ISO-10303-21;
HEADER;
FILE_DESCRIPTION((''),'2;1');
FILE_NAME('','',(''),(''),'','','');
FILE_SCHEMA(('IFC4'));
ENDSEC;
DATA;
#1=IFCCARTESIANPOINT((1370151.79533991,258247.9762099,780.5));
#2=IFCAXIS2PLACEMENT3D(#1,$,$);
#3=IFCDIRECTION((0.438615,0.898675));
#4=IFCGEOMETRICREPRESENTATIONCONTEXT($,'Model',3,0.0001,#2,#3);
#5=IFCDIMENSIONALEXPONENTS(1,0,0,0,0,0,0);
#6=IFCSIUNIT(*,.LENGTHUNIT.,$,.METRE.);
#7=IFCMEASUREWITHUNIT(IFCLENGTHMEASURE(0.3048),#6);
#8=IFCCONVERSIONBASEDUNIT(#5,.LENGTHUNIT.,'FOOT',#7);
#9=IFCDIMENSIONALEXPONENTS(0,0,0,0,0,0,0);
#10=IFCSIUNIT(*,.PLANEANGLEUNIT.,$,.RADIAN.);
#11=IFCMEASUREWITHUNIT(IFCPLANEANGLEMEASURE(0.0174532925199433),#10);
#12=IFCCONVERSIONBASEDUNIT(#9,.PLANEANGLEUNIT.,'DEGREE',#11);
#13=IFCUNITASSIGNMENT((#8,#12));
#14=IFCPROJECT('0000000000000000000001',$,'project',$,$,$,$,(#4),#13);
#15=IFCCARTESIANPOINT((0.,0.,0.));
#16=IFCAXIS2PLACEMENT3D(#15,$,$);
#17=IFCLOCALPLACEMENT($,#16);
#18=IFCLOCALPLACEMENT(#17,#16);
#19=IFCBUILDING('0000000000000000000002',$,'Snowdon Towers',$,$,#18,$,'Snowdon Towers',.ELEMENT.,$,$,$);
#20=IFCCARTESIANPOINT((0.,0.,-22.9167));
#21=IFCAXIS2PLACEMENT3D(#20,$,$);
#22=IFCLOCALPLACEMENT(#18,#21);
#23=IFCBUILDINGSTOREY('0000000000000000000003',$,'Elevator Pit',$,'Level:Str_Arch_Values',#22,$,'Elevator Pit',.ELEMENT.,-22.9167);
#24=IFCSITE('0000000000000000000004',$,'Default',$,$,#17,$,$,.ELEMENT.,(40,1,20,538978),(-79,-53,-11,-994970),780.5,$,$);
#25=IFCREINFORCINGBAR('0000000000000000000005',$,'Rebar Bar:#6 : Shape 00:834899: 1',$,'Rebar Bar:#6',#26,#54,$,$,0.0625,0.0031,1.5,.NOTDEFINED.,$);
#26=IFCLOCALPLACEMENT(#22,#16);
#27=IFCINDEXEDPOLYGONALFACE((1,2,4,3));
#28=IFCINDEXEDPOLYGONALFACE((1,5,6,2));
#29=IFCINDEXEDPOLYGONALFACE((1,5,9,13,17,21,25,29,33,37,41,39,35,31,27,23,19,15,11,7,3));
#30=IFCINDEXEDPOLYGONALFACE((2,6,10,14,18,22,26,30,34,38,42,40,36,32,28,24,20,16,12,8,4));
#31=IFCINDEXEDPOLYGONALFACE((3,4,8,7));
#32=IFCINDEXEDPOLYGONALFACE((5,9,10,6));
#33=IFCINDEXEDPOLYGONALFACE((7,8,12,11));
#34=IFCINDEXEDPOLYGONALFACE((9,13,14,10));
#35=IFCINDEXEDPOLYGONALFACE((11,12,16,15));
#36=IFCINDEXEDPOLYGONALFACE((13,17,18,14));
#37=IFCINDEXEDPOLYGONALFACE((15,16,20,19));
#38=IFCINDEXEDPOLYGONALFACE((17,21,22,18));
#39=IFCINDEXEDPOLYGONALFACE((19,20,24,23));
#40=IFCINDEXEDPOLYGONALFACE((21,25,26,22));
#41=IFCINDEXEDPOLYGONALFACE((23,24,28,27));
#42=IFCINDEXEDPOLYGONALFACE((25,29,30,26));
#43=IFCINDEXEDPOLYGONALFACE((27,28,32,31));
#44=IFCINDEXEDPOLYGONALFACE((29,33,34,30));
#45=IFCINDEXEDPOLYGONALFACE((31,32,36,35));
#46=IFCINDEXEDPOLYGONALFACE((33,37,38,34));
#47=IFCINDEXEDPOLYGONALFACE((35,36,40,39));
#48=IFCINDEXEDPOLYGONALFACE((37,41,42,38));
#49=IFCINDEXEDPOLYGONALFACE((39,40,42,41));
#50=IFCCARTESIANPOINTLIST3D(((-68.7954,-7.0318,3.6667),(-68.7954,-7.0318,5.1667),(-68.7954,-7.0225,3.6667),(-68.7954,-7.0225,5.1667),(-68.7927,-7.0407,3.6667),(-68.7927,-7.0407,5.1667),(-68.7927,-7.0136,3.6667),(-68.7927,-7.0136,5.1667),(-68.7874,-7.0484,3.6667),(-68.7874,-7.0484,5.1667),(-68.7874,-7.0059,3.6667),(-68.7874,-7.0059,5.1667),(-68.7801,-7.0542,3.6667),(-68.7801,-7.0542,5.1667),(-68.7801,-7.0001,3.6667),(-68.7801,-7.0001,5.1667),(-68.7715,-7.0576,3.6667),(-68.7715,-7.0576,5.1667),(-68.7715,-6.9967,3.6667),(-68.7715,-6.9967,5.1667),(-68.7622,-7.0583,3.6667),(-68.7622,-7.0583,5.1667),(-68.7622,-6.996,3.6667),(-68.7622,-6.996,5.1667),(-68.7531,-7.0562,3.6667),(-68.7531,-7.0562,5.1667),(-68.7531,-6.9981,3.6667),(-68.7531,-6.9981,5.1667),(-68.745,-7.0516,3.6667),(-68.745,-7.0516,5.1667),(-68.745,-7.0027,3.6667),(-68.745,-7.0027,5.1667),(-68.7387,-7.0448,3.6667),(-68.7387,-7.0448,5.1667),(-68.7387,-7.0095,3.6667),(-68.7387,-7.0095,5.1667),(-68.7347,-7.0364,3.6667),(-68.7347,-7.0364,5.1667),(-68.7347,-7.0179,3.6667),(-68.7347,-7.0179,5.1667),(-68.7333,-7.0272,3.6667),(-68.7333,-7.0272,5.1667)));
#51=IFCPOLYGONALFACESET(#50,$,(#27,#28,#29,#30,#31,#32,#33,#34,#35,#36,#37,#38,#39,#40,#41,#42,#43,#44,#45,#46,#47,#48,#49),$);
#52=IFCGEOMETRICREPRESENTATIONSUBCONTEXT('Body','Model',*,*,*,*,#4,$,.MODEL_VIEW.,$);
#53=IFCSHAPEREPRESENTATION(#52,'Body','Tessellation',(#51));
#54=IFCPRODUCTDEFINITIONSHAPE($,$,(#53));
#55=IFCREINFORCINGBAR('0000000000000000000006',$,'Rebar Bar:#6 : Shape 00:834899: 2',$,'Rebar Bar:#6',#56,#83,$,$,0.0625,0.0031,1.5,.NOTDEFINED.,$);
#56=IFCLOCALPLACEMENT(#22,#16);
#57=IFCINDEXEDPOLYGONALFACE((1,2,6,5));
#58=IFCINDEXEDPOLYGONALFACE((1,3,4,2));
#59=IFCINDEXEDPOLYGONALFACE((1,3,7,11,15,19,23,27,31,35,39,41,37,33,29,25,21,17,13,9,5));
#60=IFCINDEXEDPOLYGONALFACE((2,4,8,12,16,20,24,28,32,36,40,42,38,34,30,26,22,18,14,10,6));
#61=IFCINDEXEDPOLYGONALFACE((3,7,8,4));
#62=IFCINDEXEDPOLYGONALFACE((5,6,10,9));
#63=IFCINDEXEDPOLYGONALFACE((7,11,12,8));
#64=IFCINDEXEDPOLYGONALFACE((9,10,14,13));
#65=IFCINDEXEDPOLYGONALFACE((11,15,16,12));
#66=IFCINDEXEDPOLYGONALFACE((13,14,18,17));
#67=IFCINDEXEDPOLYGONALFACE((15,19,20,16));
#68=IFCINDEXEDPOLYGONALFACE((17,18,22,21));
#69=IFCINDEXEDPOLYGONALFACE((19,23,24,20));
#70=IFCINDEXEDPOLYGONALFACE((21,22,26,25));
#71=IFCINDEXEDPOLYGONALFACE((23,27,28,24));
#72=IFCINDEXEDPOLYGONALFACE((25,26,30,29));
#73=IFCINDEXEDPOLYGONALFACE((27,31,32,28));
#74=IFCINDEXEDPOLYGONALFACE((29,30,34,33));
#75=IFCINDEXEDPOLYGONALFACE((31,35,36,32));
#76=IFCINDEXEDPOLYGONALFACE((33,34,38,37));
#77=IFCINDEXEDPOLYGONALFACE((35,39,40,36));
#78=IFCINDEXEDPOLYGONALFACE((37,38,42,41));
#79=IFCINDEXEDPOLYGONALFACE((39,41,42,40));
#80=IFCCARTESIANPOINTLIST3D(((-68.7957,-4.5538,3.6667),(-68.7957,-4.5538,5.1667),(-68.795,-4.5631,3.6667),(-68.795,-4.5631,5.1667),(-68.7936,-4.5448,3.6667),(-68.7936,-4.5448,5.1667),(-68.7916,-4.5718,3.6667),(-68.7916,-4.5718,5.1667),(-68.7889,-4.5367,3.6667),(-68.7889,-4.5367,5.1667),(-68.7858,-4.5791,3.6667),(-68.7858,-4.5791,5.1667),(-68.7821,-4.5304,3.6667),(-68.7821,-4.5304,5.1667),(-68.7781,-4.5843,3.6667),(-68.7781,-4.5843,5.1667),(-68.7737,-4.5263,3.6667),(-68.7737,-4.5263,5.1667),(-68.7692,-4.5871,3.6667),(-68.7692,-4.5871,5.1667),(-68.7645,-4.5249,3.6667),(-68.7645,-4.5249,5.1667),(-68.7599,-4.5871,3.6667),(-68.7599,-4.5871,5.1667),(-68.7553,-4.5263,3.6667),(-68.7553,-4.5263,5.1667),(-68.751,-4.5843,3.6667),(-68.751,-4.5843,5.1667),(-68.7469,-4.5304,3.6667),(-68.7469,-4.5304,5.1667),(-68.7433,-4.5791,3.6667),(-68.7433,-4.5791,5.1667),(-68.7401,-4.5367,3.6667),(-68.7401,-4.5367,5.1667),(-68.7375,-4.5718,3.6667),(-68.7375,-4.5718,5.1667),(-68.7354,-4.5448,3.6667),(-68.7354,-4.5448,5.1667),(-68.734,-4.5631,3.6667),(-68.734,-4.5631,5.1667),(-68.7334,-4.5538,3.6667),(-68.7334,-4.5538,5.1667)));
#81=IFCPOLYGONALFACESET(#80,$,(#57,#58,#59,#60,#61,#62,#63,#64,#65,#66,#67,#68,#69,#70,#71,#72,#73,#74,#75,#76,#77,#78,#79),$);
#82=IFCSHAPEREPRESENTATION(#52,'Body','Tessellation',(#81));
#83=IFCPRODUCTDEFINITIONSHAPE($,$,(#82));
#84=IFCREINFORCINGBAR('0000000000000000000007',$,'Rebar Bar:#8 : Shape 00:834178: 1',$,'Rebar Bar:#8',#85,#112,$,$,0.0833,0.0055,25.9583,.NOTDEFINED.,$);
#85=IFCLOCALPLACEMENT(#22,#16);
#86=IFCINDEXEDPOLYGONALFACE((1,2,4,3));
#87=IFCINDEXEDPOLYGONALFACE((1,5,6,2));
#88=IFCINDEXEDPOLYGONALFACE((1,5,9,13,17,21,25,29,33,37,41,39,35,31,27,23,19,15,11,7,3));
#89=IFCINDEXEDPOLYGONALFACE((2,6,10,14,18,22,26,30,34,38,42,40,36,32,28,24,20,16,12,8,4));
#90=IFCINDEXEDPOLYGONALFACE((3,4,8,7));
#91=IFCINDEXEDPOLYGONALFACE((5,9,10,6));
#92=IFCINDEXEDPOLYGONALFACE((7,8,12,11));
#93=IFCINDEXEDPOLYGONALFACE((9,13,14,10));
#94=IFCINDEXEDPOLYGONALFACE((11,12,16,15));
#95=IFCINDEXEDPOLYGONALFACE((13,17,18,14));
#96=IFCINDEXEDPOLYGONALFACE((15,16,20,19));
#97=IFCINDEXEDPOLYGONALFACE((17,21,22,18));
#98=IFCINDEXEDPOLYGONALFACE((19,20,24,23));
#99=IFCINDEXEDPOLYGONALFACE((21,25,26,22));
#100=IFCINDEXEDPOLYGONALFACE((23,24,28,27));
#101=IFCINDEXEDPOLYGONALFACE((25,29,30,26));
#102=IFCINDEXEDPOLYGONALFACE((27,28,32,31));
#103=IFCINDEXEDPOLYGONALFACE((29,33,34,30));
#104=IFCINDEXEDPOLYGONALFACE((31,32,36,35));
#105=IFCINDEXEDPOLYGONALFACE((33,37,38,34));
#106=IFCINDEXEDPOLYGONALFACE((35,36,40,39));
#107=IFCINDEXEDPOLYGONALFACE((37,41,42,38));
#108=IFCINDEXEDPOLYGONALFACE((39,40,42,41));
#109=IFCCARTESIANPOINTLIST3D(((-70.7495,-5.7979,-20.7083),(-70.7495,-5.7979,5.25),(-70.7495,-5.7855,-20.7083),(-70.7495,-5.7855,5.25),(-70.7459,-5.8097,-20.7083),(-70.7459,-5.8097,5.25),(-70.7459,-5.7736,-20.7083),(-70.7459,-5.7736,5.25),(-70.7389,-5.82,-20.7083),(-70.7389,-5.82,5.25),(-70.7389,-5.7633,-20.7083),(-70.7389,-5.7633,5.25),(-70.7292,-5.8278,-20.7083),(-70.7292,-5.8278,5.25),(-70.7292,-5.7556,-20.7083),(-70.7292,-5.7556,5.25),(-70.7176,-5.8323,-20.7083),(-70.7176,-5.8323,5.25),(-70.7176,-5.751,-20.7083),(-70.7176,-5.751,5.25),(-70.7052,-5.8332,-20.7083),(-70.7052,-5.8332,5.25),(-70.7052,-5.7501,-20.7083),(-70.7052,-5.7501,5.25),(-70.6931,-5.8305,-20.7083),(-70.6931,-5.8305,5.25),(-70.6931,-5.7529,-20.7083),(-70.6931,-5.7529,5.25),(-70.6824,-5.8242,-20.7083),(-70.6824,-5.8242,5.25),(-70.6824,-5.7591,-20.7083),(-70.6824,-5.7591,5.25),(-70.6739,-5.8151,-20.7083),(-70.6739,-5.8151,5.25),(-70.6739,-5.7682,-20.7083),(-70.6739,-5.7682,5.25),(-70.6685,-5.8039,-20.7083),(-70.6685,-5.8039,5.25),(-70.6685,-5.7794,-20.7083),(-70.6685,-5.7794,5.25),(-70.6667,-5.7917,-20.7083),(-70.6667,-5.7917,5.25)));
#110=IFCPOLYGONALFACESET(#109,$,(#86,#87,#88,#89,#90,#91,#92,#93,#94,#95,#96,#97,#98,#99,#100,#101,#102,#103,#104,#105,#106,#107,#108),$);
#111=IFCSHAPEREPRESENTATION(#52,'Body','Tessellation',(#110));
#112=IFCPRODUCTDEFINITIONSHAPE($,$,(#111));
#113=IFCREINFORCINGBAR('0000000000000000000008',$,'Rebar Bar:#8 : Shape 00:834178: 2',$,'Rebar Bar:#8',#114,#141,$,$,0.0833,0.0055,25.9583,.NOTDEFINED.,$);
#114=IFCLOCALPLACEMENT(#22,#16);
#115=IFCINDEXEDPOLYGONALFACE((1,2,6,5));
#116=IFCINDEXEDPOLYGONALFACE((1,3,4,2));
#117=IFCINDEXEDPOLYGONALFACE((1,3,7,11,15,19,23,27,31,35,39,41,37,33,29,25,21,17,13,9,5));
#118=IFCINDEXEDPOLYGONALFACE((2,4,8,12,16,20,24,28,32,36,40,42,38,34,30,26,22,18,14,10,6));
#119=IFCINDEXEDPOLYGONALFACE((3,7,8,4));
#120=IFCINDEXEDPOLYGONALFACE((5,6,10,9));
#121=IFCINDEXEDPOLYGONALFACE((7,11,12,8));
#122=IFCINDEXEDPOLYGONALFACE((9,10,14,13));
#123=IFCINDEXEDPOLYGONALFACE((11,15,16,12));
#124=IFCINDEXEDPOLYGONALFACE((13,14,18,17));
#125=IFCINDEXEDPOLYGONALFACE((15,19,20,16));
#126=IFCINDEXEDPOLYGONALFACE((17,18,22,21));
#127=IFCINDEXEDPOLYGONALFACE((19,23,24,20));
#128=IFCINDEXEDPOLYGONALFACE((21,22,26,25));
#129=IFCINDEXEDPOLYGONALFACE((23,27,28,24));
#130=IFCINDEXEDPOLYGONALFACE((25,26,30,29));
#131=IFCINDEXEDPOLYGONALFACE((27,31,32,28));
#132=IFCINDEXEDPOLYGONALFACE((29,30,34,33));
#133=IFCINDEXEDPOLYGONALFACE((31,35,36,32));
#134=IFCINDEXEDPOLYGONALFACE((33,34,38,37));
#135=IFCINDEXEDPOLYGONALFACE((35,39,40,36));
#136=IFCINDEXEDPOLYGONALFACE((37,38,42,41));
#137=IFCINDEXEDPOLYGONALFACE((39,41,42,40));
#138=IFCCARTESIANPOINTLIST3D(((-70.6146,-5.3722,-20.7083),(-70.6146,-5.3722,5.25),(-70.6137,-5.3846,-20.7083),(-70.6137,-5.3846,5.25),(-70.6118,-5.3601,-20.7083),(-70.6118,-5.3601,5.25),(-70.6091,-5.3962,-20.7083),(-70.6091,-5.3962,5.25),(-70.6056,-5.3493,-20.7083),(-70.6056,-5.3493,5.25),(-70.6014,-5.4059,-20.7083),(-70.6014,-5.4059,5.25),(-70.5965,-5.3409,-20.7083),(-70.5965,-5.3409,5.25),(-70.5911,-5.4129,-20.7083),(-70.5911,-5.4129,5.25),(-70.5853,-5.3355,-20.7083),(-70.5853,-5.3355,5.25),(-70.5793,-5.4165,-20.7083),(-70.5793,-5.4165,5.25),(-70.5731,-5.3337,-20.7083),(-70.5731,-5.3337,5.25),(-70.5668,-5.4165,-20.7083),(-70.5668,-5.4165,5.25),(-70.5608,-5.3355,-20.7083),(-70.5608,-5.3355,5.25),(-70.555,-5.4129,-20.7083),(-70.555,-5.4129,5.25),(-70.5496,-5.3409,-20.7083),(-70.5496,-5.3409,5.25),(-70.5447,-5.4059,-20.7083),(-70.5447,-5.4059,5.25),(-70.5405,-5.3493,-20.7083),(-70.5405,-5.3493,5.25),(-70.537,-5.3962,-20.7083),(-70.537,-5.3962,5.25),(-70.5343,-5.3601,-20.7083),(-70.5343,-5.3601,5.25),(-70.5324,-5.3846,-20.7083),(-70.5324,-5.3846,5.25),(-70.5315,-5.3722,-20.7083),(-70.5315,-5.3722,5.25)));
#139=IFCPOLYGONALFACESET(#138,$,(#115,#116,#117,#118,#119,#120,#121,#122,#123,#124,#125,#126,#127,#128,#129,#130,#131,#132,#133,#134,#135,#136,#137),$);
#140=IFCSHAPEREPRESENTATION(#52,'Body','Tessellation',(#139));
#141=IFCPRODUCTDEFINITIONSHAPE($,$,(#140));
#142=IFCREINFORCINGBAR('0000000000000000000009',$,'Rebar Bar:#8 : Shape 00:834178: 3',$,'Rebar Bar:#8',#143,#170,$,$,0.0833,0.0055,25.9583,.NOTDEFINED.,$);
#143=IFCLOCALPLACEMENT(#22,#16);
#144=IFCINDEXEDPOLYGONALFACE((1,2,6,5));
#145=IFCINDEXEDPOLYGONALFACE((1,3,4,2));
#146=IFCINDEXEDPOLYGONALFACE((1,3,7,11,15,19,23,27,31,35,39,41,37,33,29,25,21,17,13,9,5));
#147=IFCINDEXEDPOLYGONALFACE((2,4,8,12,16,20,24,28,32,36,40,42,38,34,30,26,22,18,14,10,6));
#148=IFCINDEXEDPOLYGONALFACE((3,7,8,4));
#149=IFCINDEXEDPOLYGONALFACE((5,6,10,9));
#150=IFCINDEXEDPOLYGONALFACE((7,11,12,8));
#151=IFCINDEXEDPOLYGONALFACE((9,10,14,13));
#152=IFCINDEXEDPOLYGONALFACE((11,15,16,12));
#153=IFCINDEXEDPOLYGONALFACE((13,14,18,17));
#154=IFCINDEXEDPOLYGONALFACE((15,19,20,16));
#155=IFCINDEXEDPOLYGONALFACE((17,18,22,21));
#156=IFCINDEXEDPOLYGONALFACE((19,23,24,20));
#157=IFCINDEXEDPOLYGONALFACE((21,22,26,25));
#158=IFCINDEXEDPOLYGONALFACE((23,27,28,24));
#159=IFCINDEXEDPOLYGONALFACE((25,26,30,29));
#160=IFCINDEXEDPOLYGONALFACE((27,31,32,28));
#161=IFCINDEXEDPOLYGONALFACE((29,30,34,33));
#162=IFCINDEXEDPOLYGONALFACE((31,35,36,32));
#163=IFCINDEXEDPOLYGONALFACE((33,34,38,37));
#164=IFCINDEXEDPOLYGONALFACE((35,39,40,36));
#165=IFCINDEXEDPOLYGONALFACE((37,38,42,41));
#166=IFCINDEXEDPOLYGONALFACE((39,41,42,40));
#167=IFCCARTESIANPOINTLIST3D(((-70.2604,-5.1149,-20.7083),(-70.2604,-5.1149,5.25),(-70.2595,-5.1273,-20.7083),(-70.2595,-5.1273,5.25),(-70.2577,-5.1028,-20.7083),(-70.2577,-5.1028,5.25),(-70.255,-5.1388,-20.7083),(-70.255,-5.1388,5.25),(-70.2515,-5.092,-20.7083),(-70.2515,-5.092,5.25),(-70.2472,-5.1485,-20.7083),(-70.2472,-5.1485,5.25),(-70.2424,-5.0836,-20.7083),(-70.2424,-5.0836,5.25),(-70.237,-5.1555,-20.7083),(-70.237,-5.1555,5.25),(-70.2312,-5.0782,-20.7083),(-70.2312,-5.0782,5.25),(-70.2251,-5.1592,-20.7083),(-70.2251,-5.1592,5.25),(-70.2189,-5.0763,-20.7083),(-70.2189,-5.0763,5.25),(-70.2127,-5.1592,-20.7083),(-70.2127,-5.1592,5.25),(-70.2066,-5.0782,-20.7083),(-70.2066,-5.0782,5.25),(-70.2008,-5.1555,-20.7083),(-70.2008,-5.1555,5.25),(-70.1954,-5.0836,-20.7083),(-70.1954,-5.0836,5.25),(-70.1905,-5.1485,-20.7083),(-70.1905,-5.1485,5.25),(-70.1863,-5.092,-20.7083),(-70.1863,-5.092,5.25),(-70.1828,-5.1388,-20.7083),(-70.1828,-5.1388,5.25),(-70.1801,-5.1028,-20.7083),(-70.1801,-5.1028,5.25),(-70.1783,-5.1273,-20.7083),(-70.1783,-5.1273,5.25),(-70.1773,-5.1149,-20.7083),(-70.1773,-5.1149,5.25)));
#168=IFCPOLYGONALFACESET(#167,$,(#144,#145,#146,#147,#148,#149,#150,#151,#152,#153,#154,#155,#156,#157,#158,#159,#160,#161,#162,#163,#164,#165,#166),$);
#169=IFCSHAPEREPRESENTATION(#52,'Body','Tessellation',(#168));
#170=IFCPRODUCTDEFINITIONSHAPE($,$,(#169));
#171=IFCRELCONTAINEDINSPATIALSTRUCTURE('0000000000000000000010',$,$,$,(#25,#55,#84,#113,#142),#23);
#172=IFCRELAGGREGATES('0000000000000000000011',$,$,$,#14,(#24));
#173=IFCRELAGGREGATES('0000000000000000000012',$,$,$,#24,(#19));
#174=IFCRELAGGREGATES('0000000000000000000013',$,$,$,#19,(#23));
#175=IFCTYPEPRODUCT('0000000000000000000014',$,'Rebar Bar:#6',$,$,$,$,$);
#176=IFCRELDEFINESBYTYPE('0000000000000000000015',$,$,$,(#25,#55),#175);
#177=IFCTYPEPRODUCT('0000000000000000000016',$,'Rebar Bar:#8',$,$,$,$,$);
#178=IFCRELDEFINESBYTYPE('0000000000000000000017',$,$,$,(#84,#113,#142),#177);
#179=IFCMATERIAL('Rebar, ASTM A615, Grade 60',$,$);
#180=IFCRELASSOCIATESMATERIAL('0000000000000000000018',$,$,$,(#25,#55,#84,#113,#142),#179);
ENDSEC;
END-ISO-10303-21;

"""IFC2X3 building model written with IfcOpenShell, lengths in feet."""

from ifc_helpers import new_model, entity, si_unit, converted_unit, direction, frame, origin, place, context, subcontext, project, spatial, material, type_object, element, save


model = new_model("IFC2X3")

# Units and contexts
model_context = context("Model", 3, precision=0.0001, world=frame((1370151.79533991, 258247.9762099, 780.5)), true_north=direction((0.438615, 0.898675)))
body_context = subcontext(model_context, "Body", "Model", "MODEL_VIEW")
ifc_project = project(units=[converted_unit("LENGTHUNIT", "FOOT", entity("IfcLengthMeasure", 0.3048), si_unit("LENGTHUNIT", "METRE"), dimensions=[1, 0, 0, 0, 0, 0, 0]), converted_unit("PLANEANGLEUNIT", "DEGREE", entity("IfcPlaneAngleMeasure", 0.0174532925199433), si_unit("PLANEANGLEUNIT", "RADIAN"), dimensions=[0, 0, 0, 0, 0, 0, 0])], contexts=[model_context])

# Site, building, storey
site_placement = place(None, origin())
site = spatial("IfcSite", under=ifc_project, at=site_placement, Name="Default", CompositionType="ELEMENT", RefLatitude=(40, 1, 20, 538978), RefLongitude=(-79, -53, -11, -994970), RefElevation=780.5)
building_placement = place(site_placement, origin())
building = spatial("IfcBuilding", under=site, at=building_placement, Name="Snowdon Towers", LongName="Snowdon Towers", CompositionType="ELEMENT")
storey_placement = place(building_placement, frame((0.0, 0.0, -22.9167)))
storey = spatial("IfcBuildingStorey", under=building, at=storey_placement, Name="Elevator Pit", ObjectType="Level:Str_Arch_Values", LongName="Elevator Pit", CompositionType="ELEMENT", Elevation=-22.9167)

# Reinforcing bars
ifc_material = material(Name="Rebar, ASTM A615, Grade 60")
type_product_1 = type_object("IfcTypeProduct", Name="Rebar Bar:#6")
reinforcing_bar_1_placement = place(storey_placement, origin())
element("IfcReinforcingBar", 1, at=reinforcing_bar_1_placement, inside=storey, type_object=type_product_1, material=ifc_material, Name="Rebar Bar:#6 : Shape 00:834899: 1", ObjectType="Rebar Bar:#6", BarLength=1.5, BarRole="NOTDEFINED", CrossSectionArea=0.0031, NominalDiameter=0.0625, context=body_context, shape_type="AdvancedSweptSolid", body=[
    entity("IfcSweptDiskSolid", entity("IfcCompositeCurve", [entity("IfcCompositeCurveSegment", "CONTINUOUS", True, entity("IfcPolyline", [entity("IfcCartesianPoint", [-68.7645, -7.0272, 3.6667]), entity("IfcCartesianPoint", [-68.7645, -7.0272, 5.1667])]))], False), 0.0312, None, 0.0, 1.0),
])
reinforcing_bar_2_placement = place(storey_placement, origin())
element("IfcReinforcingBar", 2, at=reinforcing_bar_2_placement, inside=storey, type_object=type_product_1, material=ifc_material, Name="Rebar Bar:#6 : Shape 00:834899: 2", ObjectType="Rebar Bar:#6", BarLength=1.5, BarRole="NOTDEFINED", CrossSectionArea=0.0031, NominalDiameter=0.0625, context=body_context, shape_type="AdvancedSweptSolid", body=[
    entity("IfcSweptDiskSolid", entity("IfcCompositeCurve", [entity("IfcCompositeCurveSegment", "CONTINUOUS", True, entity("IfcPolyline", [entity("IfcCartesianPoint", [-68.7645, -4.5562, 3.6667]), entity("IfcCartesianPoint", [-68.7645, -4.5562, 5.1667])]))], False), 0.0312, None, 0.0, 1.0),
])
type_product_2 = type_object("IfcTypeProduct", Name="Rebar Bar:#8")
reinforcing_bar_3_placement = place(storey_placement, origin())
element("IfcReinforcingBar", 3, at=reinforcing_bar_3_placement, inside=storey, type_object=type_product_2, material=ifc_material, Name="Rebar Bar:#8 : Shape 00:834178: 1", ObjectType="Rebar Bar:#8", BarLength=25.9583, BarRole="NOTDEFINED", CrossSectionArea=0.0055, NominalDiameter=0.0833, context=body_context, shape_type="AdvancedSweptSolid", body=[
    entity("IfcSweptDiskSolid", entity("IfcCompositeCurve", [entity("IfcCompositeCurveSegment", "CONTINUOUS", True, entity("IfcPolyline", [entity("IfcCartesianPoint", [-70.7083, -5.7917, -20.7083]), entity("IfcCartesianPoint", [-70.7083, -5.7917, 5.25])]))], False), 0.0417, None, 0.0, 1.0),
])
reinforcing_bar_4_placement = place(storey_placement, origin())
element("IfcReinforcingBar", 4, at=reinforcing_bar_4_placement, inside=storey, type_object=type_product_2, material=ifc_material, Name="Rebar Bar:#8 : Shape 00:834178: 2", ObjectType="Rebar Bar:#8", BarLength=25.9583, BarRole="NOTDEFINED", CrossSectionArea=0.0055, NominalDiameter=0.0833, context=body_context, shape_type="AdvancedSweptSolid", body=[
    entity("IfcSweptDiskSolid", entity("IfcCompositeCurve", [entity("IfcCompositeCurveSegment", "CONTINUOUS", True, entity("IfcPolyline", [entity("IfcCartesianPoint", [-70.5731, -5.3753, -20.7083]), entity("IfcCartesianPoint", [-70.5731, -5.3753, 5.25])]))], False), 0.0417, None, 0.0, 1.0),
])
reinforcing_bar_5_placement = place(storey_placement, origin())
element("IfcReinforcingBar", 5, at=reinforcing_bar_5_placement, inside=storey, type_object=type_product_2, material=ifc_material, Name="Rebar Bar:#8 : Shape 00:834178: 3", ObjectType="Rebar Bar:#8", BarLength=25.9583, BarRole="NOTDEFINED", CrossSectionArea=0.0055, NominalDiameter=0.0833, context=body_context, shape_type="AdvancedSweptSolid", body=[
    entity("IfcSweptDiskSolid", entity("IfcCompositeCurve", [entity("IfcCompositeCurveSegment", "CONTINUOUS", True, entity("IfcPolyline", [entity("IfcCartesianPoint", [-70.2189, -5.118, -20.7083]), entity("IfcCartesianPoint", [-70.2189, -5.118, 5.25])]))], False), 0.0417, None, 0.0, 1.0),
])

save(model, "model.ifc")
